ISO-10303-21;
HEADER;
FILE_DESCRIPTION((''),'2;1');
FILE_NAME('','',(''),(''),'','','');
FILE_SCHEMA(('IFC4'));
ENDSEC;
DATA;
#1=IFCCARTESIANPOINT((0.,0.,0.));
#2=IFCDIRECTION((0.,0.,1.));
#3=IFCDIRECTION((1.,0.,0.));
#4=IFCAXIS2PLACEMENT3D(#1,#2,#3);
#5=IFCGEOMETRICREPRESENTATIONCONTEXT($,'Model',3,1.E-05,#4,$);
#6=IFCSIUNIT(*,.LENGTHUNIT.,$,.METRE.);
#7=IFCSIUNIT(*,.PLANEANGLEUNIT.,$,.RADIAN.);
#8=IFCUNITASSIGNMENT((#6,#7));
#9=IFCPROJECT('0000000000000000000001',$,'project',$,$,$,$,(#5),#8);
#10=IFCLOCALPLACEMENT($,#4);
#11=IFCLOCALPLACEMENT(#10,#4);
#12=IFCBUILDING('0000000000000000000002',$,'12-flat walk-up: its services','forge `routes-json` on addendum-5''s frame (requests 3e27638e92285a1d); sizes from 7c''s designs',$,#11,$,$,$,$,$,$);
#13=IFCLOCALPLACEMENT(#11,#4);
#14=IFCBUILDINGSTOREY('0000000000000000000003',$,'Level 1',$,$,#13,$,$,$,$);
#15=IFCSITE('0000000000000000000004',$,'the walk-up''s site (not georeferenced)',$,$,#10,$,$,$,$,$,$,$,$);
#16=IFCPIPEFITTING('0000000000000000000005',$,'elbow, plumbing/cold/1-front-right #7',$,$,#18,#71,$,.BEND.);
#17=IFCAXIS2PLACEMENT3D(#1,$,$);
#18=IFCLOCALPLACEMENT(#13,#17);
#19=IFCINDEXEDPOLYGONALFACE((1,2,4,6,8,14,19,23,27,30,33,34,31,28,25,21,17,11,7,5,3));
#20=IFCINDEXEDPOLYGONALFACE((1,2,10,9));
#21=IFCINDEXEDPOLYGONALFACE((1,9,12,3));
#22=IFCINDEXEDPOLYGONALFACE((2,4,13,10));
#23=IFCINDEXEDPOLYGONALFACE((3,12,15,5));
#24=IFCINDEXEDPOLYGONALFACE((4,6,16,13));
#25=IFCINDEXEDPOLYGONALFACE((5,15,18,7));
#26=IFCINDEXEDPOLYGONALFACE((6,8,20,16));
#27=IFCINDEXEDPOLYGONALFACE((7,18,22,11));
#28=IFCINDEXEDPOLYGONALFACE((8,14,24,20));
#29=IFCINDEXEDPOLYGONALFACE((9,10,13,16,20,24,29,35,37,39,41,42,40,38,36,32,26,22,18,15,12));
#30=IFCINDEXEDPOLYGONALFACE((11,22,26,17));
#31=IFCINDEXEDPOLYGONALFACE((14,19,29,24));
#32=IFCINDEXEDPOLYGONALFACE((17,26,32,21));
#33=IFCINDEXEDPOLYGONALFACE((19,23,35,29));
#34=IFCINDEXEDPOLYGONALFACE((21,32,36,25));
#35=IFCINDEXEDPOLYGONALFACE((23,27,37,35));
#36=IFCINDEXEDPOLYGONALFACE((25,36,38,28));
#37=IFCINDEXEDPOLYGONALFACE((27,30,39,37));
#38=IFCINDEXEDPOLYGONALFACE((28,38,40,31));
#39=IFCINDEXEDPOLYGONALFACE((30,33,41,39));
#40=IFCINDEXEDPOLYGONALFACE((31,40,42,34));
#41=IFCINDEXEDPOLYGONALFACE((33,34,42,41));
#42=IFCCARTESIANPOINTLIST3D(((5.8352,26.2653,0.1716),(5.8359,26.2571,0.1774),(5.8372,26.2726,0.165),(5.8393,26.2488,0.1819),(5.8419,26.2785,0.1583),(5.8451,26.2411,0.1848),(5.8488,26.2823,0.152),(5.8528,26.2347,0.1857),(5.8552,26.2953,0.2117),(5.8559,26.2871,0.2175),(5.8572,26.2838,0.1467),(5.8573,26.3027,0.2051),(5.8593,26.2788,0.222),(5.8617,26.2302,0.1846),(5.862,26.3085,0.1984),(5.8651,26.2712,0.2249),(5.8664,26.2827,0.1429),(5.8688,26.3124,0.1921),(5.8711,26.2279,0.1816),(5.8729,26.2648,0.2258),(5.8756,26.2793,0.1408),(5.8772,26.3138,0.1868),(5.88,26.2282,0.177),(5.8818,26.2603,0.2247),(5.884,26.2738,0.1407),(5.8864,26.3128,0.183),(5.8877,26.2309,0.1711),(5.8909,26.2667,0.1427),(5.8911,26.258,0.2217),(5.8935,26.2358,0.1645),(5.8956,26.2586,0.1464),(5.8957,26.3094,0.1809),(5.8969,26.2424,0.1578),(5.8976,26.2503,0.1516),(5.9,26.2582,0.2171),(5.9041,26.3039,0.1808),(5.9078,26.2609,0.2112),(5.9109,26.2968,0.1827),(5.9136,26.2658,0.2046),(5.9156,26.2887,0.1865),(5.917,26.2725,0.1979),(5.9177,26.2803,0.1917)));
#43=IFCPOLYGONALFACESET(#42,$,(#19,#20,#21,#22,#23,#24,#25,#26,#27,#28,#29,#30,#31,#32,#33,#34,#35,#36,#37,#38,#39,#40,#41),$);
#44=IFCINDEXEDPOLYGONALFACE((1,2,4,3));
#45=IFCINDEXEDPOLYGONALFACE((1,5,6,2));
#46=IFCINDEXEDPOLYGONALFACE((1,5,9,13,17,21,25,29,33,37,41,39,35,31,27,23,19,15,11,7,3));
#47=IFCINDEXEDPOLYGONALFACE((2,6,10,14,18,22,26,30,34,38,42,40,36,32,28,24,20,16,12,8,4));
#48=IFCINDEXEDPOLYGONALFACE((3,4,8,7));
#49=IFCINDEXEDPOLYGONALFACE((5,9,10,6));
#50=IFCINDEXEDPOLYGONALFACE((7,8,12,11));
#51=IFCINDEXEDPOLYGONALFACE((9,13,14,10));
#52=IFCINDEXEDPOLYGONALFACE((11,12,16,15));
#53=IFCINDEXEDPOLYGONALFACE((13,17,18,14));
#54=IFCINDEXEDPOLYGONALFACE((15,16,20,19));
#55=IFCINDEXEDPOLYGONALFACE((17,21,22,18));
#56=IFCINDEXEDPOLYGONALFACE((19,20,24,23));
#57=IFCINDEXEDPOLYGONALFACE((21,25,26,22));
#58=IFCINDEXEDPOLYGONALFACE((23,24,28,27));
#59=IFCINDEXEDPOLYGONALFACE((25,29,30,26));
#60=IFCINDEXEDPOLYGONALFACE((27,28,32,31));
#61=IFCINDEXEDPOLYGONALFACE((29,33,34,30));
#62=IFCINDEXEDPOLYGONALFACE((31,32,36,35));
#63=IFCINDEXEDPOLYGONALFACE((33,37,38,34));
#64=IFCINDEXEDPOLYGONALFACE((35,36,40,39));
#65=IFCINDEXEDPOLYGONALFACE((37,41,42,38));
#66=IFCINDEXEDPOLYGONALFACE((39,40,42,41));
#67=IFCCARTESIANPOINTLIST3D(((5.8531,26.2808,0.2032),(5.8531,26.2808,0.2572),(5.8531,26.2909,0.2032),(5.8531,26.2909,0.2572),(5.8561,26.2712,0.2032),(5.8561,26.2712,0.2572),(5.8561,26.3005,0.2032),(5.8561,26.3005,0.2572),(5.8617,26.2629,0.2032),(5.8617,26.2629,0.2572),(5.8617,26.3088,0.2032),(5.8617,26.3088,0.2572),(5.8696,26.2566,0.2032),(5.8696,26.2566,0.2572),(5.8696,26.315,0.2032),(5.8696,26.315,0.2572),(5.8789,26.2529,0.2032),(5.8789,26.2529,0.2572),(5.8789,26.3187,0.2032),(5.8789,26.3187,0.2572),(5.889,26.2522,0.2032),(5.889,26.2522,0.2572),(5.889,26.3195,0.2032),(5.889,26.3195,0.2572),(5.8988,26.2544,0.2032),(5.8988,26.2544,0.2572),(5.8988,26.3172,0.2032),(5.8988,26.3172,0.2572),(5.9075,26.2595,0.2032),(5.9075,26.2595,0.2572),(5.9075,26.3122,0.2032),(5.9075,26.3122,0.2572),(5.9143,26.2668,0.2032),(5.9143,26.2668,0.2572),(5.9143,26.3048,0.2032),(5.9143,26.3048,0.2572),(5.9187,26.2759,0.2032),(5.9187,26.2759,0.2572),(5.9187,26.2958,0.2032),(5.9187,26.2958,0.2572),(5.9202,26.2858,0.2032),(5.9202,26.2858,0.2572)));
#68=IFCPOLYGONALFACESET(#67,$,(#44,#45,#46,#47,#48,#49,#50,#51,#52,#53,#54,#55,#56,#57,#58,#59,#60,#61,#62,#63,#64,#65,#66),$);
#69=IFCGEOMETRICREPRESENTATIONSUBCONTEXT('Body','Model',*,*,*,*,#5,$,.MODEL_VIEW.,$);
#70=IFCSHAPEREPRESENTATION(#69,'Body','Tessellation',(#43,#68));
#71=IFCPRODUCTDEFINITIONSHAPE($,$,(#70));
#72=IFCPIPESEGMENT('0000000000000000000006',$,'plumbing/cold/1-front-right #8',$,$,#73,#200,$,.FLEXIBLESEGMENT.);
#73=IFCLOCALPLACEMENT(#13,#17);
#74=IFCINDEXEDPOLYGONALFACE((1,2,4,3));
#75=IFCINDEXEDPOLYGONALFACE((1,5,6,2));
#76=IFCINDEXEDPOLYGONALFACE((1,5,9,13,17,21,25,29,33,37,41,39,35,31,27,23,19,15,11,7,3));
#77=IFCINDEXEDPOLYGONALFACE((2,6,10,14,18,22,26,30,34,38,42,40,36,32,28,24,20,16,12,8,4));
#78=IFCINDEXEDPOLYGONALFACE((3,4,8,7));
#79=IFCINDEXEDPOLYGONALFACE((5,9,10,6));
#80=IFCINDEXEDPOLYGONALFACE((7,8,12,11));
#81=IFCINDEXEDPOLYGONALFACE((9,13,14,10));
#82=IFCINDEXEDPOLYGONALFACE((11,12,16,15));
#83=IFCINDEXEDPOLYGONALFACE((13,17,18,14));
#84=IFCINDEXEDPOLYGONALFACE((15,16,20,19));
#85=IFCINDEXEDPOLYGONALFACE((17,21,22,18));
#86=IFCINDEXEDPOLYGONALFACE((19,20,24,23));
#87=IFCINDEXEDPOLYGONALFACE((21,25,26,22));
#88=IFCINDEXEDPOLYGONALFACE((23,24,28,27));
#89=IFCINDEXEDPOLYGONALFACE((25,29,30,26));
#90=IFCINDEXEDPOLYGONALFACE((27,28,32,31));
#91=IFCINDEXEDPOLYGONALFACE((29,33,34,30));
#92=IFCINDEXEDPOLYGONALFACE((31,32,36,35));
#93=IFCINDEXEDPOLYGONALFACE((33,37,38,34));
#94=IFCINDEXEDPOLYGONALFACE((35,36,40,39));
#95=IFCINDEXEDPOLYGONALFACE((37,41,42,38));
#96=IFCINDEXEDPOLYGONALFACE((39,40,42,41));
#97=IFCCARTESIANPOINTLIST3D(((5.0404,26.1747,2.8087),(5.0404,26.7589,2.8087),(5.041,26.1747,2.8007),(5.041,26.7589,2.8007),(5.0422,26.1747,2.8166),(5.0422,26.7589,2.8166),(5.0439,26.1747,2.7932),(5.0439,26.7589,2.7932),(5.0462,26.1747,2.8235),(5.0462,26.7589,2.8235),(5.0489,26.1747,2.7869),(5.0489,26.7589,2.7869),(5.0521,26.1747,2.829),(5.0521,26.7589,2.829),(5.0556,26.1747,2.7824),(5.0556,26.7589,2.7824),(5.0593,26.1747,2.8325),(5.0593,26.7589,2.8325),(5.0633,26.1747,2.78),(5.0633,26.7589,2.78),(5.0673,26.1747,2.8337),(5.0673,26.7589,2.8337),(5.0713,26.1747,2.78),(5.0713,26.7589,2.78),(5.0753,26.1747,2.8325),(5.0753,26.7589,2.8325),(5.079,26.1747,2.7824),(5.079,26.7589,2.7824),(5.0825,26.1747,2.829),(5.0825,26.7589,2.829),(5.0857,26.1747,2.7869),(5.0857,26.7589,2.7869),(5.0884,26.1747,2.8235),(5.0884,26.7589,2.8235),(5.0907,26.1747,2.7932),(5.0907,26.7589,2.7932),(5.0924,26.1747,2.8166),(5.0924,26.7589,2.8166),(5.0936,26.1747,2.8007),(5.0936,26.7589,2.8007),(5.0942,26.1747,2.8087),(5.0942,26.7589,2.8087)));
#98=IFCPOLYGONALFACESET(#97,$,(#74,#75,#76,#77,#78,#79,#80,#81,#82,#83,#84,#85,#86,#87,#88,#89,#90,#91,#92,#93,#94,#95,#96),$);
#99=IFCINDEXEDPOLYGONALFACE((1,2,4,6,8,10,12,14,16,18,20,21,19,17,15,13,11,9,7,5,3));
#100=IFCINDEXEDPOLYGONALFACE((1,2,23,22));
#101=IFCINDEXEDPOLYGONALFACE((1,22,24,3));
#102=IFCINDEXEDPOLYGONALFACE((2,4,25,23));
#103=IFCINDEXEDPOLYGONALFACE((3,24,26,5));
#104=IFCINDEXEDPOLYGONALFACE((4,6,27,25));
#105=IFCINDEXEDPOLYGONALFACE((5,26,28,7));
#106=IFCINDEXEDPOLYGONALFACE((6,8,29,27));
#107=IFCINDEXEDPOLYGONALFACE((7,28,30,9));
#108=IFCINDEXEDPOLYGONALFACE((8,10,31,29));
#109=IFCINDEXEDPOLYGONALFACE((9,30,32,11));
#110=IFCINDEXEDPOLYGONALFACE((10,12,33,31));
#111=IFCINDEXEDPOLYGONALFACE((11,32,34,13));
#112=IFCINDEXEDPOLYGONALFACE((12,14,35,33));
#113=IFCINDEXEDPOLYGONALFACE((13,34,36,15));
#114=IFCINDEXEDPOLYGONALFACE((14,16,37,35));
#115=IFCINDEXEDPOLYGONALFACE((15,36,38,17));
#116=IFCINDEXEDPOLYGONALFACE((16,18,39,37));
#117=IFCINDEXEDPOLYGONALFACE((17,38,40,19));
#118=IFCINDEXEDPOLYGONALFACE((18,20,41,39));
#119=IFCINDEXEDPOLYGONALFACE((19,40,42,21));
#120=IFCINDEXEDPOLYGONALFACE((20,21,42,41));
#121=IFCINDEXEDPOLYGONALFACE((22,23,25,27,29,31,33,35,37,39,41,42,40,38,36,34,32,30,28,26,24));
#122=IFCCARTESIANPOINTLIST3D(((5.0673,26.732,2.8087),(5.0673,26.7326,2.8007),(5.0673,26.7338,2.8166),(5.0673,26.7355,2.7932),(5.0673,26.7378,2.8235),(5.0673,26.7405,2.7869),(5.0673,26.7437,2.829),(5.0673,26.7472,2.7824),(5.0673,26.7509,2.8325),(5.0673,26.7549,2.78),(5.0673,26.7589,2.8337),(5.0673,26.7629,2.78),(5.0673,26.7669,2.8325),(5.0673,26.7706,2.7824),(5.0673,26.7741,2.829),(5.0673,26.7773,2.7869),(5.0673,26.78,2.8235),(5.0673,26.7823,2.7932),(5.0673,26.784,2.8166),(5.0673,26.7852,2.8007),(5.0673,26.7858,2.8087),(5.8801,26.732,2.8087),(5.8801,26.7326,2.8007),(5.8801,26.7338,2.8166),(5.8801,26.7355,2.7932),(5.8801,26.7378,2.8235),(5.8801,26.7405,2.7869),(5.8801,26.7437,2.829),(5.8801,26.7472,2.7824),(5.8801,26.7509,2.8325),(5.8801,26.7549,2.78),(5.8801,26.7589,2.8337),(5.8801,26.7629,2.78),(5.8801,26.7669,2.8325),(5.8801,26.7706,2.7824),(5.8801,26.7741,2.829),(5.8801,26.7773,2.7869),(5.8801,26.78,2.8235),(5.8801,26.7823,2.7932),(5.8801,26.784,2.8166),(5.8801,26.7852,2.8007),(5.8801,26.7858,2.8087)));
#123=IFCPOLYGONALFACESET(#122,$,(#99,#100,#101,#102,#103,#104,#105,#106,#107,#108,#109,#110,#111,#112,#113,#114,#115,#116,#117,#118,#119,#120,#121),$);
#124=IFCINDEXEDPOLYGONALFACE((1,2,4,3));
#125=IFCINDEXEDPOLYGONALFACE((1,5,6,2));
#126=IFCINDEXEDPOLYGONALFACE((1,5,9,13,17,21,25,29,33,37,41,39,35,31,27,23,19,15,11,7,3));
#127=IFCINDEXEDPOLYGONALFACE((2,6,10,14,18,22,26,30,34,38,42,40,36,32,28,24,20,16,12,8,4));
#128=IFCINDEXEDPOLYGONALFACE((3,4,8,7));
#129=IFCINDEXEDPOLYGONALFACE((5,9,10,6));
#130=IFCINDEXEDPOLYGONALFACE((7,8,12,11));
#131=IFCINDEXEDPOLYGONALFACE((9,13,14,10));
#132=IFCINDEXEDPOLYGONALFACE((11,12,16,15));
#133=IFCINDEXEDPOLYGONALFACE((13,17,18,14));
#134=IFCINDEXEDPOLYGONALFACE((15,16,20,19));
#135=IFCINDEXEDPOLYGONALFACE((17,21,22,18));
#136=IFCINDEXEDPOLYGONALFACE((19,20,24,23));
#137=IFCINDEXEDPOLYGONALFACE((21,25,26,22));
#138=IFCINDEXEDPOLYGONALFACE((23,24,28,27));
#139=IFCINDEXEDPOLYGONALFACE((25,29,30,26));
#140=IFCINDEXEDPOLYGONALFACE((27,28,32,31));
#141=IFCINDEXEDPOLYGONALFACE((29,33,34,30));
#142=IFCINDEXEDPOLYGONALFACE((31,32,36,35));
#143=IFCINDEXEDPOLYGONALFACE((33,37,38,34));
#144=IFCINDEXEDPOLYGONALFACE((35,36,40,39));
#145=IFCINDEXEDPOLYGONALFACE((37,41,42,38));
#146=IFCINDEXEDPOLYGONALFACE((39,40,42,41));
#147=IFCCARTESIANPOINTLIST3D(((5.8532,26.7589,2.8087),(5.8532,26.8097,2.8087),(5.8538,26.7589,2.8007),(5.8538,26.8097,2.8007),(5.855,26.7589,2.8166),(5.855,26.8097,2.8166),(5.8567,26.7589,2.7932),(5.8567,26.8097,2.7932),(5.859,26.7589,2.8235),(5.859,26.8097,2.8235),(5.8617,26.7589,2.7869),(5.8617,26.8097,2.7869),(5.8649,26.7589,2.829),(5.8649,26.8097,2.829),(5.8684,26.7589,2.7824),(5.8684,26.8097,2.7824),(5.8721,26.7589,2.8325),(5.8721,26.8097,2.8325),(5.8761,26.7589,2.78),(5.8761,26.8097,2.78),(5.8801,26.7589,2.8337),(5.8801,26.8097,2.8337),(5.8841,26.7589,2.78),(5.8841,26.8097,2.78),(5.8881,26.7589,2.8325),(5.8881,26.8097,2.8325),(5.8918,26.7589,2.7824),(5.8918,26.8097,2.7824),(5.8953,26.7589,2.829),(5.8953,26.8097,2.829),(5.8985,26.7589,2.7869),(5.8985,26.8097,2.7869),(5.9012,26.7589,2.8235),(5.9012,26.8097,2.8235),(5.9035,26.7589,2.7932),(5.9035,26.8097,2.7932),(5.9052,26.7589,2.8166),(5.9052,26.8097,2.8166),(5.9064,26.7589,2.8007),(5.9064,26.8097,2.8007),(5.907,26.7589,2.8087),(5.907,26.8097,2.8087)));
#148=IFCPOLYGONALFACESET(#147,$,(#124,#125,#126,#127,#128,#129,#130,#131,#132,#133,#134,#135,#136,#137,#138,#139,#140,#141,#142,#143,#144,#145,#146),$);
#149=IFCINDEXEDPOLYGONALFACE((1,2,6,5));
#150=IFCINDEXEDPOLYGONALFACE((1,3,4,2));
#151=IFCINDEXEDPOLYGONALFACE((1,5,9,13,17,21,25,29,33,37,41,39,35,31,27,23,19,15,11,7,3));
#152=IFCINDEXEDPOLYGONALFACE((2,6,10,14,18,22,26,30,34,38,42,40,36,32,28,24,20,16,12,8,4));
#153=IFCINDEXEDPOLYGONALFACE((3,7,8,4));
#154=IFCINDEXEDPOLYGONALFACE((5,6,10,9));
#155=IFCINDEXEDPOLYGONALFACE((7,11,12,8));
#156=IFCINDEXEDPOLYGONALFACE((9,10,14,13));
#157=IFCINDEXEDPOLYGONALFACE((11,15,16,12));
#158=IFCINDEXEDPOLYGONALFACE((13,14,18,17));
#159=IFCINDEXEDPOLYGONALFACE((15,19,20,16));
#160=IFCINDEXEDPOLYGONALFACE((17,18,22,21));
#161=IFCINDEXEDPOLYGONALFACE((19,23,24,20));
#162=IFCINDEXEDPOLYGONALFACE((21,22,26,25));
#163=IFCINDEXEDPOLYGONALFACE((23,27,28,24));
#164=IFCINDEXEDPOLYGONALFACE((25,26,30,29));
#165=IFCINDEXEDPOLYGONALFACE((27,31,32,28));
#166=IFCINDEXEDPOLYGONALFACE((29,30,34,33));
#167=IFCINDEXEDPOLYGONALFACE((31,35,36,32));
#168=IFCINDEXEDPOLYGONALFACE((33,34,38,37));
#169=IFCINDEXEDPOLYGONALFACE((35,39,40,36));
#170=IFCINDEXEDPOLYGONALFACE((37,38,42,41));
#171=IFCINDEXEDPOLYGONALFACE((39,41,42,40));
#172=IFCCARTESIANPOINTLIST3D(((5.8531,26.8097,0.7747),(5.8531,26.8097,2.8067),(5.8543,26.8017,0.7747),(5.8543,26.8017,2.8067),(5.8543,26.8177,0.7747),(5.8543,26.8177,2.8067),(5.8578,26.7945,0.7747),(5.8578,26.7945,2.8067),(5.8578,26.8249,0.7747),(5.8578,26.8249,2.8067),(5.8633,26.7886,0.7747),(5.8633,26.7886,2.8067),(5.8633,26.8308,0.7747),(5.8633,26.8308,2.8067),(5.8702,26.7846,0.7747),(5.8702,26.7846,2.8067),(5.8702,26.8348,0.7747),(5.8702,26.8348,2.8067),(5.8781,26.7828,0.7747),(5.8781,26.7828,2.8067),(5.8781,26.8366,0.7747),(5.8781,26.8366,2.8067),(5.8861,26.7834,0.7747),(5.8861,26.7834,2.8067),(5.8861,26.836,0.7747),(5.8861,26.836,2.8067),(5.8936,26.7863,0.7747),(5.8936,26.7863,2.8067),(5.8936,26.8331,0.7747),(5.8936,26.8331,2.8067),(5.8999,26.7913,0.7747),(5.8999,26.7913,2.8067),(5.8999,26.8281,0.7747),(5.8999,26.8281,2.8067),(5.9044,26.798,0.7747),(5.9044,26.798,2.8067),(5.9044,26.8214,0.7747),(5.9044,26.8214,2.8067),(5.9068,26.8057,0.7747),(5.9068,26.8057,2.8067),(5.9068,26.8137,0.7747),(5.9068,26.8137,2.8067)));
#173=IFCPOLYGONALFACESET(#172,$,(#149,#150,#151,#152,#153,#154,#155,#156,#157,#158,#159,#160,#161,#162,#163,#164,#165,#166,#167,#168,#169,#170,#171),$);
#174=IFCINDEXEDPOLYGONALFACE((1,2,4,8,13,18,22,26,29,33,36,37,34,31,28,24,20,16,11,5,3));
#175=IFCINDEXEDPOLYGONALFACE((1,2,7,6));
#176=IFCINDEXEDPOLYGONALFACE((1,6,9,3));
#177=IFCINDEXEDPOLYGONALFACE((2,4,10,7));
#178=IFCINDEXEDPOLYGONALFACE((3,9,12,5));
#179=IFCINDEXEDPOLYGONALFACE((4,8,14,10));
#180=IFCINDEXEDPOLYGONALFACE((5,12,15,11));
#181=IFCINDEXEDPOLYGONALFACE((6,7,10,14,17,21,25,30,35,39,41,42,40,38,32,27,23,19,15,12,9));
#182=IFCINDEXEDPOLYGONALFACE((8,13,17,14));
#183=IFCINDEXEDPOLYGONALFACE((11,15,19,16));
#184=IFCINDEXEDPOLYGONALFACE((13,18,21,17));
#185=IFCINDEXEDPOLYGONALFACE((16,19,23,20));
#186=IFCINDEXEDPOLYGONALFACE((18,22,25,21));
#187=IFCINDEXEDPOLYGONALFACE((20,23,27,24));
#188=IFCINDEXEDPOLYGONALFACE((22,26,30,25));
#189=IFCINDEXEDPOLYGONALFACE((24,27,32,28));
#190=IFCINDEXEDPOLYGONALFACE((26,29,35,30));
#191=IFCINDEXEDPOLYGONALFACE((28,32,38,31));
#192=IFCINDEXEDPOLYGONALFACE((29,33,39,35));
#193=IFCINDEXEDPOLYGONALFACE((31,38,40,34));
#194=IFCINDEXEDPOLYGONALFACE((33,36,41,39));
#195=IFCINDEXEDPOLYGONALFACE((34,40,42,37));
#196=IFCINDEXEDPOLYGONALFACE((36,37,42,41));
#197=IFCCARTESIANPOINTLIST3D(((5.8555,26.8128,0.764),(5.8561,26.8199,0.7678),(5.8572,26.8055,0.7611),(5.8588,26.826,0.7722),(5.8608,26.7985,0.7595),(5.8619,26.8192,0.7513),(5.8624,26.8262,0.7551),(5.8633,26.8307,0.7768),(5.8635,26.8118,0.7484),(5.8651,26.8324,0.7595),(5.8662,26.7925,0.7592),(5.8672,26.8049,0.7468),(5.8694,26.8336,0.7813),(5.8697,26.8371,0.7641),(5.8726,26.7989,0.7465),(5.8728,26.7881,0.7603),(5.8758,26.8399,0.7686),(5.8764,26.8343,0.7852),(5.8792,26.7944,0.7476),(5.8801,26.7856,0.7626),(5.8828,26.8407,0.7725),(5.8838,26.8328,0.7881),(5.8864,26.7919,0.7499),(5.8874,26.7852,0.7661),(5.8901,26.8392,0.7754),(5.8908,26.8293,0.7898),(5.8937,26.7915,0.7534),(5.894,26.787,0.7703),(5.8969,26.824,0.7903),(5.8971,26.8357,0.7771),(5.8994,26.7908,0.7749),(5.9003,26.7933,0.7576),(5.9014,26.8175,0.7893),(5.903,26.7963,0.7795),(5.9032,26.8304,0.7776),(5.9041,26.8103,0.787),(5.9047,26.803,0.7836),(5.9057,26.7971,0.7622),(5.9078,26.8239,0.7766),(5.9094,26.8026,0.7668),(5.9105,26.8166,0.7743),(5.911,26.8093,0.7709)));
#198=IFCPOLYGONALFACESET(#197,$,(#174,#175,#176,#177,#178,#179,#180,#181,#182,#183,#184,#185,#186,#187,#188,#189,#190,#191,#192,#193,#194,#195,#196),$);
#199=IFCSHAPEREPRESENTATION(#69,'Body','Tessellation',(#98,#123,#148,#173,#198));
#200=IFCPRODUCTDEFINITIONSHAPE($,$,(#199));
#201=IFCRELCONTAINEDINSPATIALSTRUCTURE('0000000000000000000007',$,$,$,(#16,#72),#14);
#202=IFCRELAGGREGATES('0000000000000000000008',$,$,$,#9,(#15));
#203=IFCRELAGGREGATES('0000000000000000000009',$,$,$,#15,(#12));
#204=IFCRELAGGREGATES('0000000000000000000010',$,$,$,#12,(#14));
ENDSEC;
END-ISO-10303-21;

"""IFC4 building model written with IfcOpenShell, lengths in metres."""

from ifc_helpers import new_model, entity, si_unit, frame, origin_with_axes, place, context, subcontext, project, spatial, element, save


model = new_model("IFC4")

# Units and contexts
model_context = context("Model", 3, precision=1e-05, world=origin_with_axes())
body_context = subcontext(model_context, "Body", "Model", "MODEL_VIEW")
ifc_project = project(units=[si_unit("LENGTHUNIT", "METRE"), si_unit("PLANEANGLEUNIT", "RADIAN")], contexts=[model_context])

# Site, building, storey
site_placement = place(None, origin_with_axes())
site = spatial("IfcSite", under=ifc_project, at=site_placement, Name="the walk-up's site (not georeferenced)")
building_placement = place(site_placement, origin_with_axes())
building = spatial("IfcBuilding", under=site, at=building_placement, Name="12-flat walk-up: its services", Description="forge `routes-json` on addendum-5's frame (requests 3e27638e92285a1d); sizes from 7c's designs")
storey_placement = place(building_placement, origin_with_axes())
storey = spatial("IfcBuildingStorey", under=building, at=storey_placement, Name="Level 1")

# Pipe fitting
pipe_fitting_1_placement = place(storey_placement, frame((5.8664, 26.2558, 0.1631), z_axis=(0.0, 0.0, 1.0), x_axis=(1.0, 0.0, 0.0)))
element("IfcPipeFitting", 1, at=pipe_fitting_1_placement, inside=storey, Name="elbow, plumbing/cold/1-front-right #7", PredefinedType="BEND", context=body_context, shape_type="AdvancedSweptSolid", body=[
    entity("IfcSweptDiskSolid", entity("IfcPolyline", [entity("IfcCartesianPoint", [0.0, 0.0, 0.0]), entity("IfcCartesianPoint", [0.02, 0.0301, 0.0401])]), 0.0337),
    entity("IfcSweptDiskSolid", entity("IfcPolyline", [entity("IfcCartesianPoint", [0.02, 0.0301, 0.0401]), entity("IfcCartesianPoint", [0.02, 0.0301, 0.0941])]), 0.0337),
])

# Pipe segment
pipe_segment_1_placement = place(storey_placement, frame((5.0673, 26.1747, 2.8067), z_axis=(0.0, 0.0, 1.0), x_axis=(1.0, 0.0, 0.0)))
element("IfcPipeSegment", 2, at=pipe_segment_1_placement, inside=storey, Name="plumbing/cold/1-front-right #8", PredefinedType="FLEXIBLESEGMENT", context=body_context, shape_type="AdvancedSweptSolid", body=[
    entity("IfcSweptDiskSolid", entity("IfcPolyline", [entity("IfcCartesianPoint", [0.0, 0.0, 0.0]), entity("IfcCartesianPoint", [0.0, 0.5842, 0.0])]), 0.027),
    entity("IfcSweptDiskSolid", entity("IfcPolyline", [entity("IfcCartesianPoint", [0.0, 0.5842, 0.0]), entity("IfcCartesianPoint", [0.8128, 0.5842, 0.0])]), 0.027),
    entity("IfcSweptDiskSolid", entity("IfcPolyline", [entity("IfcCartesianPoint", [0.8128, 0.5842, 0.0]), entity("IfcCartesianPoint", [0.8128, 0.635, 0.0])]), 0.027),
    entity("IfcSweptDiskSolid", entity("IfcPolyline", [entity("IfcCartesianPoint", [0.8128, 0.635, 0.0]), entity("IfcCartesianPoint", [0.8128, 0.635, -2.032])]), 0.027),
    entity("IfcSweptDiskSolid", entity("IfcPolyline", [entity("IfcCartesianPoint", [0.8128, 0.635, -2.032]), entity("IfcCartesianPoint", [0.8192, 0.6414, -2.0447])]), 0.027),
])

save(model, "model.ifc")
